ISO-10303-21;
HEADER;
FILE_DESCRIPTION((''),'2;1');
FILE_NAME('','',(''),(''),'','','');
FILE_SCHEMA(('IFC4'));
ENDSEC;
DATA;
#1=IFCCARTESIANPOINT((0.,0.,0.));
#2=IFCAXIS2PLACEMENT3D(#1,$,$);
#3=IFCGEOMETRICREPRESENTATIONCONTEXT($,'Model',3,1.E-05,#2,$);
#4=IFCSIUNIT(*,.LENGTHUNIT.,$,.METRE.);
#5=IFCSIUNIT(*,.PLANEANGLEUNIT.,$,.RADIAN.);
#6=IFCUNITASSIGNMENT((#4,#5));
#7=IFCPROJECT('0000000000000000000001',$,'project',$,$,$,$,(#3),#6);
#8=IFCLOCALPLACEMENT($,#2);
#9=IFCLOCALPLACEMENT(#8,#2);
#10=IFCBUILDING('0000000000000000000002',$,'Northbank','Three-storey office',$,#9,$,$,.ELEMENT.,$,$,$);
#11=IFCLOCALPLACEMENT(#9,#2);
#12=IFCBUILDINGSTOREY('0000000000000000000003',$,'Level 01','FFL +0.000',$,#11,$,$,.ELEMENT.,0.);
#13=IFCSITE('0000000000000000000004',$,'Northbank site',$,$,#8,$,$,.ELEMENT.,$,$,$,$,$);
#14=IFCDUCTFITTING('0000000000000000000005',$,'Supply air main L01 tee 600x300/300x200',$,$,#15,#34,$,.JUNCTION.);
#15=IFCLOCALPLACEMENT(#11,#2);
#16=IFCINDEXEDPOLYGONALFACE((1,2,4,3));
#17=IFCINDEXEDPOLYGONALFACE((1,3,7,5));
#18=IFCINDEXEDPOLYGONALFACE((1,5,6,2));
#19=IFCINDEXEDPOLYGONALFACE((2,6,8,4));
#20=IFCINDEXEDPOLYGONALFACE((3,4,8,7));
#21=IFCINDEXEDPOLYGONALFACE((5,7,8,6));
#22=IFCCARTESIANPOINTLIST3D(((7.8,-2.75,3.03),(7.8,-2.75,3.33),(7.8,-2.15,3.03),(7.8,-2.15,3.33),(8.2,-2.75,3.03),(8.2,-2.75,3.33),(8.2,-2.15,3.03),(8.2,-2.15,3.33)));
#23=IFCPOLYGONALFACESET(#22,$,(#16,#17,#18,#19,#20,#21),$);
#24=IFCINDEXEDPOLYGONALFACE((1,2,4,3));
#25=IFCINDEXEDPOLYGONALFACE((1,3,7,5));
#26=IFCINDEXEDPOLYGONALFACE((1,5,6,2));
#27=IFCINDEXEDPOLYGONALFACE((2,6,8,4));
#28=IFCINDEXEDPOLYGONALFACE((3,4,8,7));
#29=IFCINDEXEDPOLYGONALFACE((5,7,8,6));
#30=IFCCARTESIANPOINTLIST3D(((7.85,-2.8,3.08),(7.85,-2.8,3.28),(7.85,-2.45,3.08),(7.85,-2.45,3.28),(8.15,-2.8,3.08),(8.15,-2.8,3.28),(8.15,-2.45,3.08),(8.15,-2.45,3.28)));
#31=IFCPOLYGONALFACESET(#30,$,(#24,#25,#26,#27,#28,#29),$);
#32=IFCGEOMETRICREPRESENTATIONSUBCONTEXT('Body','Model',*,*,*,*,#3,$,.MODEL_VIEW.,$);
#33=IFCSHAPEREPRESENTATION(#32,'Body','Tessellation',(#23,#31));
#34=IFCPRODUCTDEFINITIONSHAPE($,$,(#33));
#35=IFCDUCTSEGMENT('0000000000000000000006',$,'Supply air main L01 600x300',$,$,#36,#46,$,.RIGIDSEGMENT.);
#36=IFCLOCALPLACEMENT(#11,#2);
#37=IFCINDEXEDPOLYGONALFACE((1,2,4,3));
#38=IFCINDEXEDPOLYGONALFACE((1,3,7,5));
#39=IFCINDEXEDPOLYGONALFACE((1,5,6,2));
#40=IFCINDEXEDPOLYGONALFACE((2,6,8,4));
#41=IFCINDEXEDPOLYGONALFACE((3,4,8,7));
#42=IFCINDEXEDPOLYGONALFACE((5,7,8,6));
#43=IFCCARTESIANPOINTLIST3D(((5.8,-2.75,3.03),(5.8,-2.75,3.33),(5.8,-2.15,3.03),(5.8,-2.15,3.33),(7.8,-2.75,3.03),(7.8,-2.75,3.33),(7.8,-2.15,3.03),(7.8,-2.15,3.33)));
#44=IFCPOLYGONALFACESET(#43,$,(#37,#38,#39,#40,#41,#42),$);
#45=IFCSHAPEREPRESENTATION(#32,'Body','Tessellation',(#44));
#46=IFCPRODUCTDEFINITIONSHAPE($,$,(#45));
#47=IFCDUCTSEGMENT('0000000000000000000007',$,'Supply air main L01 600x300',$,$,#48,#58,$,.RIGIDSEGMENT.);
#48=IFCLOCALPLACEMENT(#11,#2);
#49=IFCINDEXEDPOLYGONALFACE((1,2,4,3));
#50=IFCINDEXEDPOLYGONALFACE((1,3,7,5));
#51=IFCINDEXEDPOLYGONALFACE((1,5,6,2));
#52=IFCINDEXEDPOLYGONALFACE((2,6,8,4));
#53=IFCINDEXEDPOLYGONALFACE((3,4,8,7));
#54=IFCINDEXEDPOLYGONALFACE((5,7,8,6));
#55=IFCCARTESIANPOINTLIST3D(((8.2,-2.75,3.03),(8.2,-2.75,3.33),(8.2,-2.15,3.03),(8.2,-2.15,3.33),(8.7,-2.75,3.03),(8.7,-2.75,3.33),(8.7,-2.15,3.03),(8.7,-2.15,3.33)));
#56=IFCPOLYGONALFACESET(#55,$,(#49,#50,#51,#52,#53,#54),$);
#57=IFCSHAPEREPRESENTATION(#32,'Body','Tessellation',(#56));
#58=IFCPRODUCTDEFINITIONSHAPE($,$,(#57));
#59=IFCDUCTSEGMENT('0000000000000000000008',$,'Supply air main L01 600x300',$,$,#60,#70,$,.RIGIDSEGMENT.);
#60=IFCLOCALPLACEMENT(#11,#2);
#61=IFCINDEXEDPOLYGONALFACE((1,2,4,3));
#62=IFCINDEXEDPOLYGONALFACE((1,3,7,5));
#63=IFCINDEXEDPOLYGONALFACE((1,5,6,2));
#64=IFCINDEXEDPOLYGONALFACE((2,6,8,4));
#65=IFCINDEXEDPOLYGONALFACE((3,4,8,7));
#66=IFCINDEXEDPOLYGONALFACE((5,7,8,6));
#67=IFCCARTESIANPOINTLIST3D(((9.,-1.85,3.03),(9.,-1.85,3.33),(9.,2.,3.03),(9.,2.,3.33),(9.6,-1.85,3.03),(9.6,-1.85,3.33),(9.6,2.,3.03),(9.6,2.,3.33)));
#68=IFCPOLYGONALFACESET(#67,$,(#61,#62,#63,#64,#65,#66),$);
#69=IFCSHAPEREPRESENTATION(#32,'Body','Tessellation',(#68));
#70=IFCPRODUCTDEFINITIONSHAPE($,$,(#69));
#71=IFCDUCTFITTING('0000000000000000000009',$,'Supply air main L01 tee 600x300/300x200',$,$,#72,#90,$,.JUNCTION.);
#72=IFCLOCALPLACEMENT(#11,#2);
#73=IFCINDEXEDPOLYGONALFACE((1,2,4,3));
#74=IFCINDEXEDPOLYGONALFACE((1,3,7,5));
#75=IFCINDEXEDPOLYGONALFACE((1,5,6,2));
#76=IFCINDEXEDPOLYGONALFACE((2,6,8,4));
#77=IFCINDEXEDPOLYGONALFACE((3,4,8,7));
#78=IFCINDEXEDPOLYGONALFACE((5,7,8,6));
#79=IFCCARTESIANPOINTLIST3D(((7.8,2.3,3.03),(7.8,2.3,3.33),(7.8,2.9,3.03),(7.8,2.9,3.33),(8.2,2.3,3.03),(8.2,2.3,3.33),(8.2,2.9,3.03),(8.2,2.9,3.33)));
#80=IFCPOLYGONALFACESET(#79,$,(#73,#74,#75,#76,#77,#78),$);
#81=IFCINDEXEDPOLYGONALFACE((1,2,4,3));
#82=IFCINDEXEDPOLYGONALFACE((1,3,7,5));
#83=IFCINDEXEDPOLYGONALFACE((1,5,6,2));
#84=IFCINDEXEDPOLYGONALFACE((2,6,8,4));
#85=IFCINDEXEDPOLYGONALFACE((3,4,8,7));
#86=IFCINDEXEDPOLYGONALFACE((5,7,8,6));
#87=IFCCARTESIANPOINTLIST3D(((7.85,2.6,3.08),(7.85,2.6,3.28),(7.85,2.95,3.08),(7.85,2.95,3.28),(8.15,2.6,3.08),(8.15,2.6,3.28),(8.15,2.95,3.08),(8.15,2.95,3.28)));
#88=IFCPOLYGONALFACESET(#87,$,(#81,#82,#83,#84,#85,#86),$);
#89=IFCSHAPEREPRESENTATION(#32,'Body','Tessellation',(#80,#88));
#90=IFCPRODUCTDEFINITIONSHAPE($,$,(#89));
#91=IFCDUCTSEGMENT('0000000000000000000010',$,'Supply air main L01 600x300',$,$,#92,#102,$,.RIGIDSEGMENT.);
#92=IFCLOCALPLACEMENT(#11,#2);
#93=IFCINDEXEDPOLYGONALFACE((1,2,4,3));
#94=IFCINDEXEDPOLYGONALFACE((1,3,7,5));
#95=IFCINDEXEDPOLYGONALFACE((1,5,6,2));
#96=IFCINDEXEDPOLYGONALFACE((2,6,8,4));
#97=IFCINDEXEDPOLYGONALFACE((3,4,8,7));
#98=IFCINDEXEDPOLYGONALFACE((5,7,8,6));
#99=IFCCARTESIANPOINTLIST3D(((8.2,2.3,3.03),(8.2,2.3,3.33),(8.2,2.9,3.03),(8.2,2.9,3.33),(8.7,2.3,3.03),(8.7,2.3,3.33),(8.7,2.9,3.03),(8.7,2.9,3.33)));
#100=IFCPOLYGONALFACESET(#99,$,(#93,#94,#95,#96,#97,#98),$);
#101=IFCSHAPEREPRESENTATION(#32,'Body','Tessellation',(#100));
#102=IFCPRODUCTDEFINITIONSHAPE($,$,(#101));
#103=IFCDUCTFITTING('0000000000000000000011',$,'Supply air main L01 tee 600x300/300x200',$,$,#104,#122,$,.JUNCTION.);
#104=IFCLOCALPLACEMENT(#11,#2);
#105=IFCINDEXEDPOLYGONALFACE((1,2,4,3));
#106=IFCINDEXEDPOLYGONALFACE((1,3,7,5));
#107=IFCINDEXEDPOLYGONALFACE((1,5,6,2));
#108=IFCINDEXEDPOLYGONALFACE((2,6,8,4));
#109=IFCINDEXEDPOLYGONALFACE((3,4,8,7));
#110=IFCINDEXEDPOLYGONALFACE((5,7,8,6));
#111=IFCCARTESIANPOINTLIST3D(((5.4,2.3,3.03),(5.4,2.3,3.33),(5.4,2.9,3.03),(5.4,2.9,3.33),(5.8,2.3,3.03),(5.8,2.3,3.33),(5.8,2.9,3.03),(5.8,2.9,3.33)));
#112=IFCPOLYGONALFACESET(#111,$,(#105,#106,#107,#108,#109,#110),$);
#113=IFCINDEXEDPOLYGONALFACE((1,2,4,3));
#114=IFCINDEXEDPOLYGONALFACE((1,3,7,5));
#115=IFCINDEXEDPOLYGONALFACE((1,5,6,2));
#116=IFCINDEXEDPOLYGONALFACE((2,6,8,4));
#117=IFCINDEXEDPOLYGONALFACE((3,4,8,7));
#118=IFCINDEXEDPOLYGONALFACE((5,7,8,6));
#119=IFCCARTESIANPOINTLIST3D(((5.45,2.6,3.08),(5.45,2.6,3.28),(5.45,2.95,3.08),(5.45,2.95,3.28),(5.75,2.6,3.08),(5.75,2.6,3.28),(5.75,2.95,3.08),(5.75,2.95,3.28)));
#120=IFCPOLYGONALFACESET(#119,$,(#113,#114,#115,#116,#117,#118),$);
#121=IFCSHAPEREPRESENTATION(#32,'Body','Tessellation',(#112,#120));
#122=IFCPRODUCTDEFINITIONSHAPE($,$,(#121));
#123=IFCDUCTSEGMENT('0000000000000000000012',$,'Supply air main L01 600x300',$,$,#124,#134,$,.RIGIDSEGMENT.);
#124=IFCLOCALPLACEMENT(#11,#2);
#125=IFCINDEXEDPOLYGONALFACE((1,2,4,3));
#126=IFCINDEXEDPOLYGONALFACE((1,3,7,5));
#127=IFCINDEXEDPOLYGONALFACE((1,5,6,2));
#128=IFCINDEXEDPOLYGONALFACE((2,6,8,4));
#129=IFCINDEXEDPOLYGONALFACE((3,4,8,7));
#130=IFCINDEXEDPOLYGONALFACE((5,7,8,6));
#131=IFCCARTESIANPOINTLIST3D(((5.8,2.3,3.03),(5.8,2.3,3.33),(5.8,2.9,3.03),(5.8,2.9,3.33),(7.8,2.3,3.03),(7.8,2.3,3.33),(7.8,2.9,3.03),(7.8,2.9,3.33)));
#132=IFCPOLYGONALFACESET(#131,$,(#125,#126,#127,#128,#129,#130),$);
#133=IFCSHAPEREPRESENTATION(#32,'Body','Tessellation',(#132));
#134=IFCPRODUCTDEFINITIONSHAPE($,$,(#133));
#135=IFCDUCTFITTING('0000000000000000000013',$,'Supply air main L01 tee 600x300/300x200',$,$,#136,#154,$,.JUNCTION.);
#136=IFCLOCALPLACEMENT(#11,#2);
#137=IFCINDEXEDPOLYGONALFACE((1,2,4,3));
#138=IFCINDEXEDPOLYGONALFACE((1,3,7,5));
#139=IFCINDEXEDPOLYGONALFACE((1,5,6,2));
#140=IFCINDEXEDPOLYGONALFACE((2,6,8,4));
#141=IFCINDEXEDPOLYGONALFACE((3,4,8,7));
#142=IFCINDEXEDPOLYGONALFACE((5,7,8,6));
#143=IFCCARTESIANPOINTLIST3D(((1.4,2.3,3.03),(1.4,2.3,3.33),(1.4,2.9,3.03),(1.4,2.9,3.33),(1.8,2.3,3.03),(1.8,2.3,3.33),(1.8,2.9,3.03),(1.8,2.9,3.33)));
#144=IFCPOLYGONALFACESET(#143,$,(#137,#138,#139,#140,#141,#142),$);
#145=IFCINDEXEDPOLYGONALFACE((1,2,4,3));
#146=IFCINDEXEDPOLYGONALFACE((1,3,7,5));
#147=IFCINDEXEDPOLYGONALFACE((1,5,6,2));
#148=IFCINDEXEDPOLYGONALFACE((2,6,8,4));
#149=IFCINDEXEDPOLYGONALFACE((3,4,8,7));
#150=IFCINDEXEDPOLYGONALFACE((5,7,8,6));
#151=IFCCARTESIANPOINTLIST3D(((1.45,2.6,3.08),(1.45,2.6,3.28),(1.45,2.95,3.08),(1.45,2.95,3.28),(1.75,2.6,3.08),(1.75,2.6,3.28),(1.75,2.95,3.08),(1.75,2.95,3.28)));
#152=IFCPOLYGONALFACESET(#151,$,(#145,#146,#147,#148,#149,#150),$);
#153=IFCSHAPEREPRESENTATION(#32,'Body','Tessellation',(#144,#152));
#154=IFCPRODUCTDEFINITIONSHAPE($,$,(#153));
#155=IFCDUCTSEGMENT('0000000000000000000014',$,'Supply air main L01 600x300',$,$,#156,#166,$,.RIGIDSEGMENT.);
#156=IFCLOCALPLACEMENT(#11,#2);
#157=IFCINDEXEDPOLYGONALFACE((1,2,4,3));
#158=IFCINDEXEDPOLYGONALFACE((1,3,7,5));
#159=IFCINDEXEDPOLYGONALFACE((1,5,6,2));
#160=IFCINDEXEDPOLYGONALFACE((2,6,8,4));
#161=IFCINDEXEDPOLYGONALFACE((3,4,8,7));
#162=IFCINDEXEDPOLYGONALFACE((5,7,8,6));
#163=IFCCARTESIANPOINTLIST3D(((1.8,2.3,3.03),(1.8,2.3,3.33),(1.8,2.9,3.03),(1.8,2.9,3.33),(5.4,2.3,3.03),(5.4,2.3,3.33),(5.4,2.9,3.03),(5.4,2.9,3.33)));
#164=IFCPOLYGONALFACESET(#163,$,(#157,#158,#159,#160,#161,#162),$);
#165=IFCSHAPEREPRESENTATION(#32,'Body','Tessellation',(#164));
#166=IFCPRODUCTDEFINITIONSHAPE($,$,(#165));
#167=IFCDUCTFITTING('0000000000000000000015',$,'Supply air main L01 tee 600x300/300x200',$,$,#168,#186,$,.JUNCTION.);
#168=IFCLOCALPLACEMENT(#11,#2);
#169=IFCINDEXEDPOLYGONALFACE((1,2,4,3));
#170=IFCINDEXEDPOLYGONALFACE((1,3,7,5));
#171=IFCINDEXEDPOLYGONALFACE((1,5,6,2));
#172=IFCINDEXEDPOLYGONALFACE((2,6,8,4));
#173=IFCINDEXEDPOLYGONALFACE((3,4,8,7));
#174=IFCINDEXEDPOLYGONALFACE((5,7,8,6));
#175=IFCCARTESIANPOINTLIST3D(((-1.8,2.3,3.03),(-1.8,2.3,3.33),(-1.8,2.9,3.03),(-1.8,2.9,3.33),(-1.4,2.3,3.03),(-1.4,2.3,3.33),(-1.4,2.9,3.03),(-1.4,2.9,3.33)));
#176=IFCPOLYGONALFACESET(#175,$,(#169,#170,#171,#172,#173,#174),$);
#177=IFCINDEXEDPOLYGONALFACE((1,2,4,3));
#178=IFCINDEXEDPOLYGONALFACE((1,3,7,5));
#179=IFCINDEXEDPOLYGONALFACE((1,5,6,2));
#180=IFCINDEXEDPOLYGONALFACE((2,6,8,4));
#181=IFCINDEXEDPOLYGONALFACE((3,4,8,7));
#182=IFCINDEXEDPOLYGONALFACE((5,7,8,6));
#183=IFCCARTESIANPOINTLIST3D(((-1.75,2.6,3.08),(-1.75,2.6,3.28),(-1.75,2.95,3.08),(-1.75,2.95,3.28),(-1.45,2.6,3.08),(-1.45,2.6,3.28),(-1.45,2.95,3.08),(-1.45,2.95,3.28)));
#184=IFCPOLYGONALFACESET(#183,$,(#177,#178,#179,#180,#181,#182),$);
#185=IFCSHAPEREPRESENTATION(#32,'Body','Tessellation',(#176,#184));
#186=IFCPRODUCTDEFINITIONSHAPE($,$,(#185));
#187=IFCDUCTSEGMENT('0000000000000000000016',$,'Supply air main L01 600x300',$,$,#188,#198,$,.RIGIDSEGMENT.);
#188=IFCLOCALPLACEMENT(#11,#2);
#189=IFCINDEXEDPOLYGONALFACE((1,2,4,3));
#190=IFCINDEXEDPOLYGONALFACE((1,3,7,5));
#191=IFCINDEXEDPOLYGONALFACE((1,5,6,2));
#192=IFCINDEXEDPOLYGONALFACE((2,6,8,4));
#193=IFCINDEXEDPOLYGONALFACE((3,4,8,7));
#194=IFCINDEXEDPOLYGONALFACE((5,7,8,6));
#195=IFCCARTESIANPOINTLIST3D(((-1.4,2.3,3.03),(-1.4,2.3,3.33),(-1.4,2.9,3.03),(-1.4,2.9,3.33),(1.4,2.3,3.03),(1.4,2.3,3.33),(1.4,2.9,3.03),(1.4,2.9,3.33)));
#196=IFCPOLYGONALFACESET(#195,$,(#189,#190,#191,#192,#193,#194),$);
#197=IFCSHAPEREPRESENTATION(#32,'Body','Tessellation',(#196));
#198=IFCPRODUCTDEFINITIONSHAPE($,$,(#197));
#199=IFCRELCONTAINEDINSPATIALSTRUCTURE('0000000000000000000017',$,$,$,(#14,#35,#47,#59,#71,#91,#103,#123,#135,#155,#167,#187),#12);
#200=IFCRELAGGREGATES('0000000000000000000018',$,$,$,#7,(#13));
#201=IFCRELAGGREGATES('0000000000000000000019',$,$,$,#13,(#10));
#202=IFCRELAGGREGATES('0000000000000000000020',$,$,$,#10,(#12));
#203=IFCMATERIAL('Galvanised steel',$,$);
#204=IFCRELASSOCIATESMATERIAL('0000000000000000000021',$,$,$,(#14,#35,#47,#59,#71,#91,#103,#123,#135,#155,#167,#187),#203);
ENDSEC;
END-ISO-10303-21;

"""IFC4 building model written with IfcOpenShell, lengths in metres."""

from ifc_helpers import new_model, si_unit, frame, origin, place, context, subcontext, project, spatial, rectangle, extrude, material, element, save


model = new_model("IFC4")

# Units and contexts
model_context = context("Model", 3, precision=1e-05, world=origin())
body_context = subcontext(model_context, "Body", "Model", "MODEL_VIEW")
ifc_project = project(units=[si_unit("LENGTHUNIT", "METRE"), si_unit("PLANEANGLEUNIT", "RADIAN")], contexts=[model_context])

# Site, building, storey
site_placement = place(None, origin())
site = spatial("IfcSite", under=ifc_project, at=site_placement, Name="Northbank site", CompositionType="ELEMENT")
building_placement = place(site_placement, origin())
building = spatial("IfcBuilding", under=site, at=building_placement, Name="Northbank", Description="Three-storey office", CompositionType="ELEMENT")
storey_placement = place(building_placement, origin())
storey = spatial("IfcBuildingStorey", under=building, at=storey_placement, Name="Level 01", Description="FFL +0.000", CompositionType="ELEMENT", Elevation=0.0)

# Shared definitions
ifc_material_1 = material(Name="Galvanised steel")

# Duct fitting
duct_fitting_1_placement = place(storey_placement, origin())
element("IfcDuctFitting", 1, at=duct_fitting_1_placement, inside=storey, material=ifc_material_1, Name="Supply air main L01 tee 600x300/300x200", PredefinedType="JUNCTION", context=body_context, shape_type="SweptSolid", body=[
    extrude(rectangle(XDim=0.6, YDim=0.3), frame((7.8, -2.45, 3.18), z_axis=(1.0, 0.0, 0.0), x_axis=(0.0, 1.0, 0.0)), (0.0, 0.0, 1.0), 0.4),
    extrude(rectangle(XDim=0.3, YDim=0.2), frame((8.0, -2.45, 3.18), z_axis=(0.0, -1.0, 0.0), x_axis=(1.0, 0.0, 0.0)), (0.0, 0.0, 1.0), 0.35),
])

# Duct segments
duct_segment_1_placement = place(storey_placement, origin())
element("IfcDuctSegment", 2, at=duct_segment_1_placement, inside=storey, material=ifc_material_1, Name="Supply air main L01 600x300", PredefinedType="RIGIDSEGMENT", context=body_context, shape_type="SweptSolid", body=[
    extrude(rectangle(XDim=0.6, YDim=0.3), frame((5.8, -2.45, 3.18), z_axis=(1.0, 0.0, 0.0), x_axis=(0.0, 1.0, 0.0)), (0.0, 0.0, 1.0), 2.0),
])
duct_segment_2_placement = place(storey_placement, origin())
element("IfcDuctSegment", 3, at=duct_segment_2_placement, inside=storey, material=ifc_material_1, Name="Supply air main L01 600x300", PredefinedType="RIGIDSEGMENT", context=body_context, shape_type="SweptSolid", body=[
    extrude(rectangle(XDim=0.6, YDim=0.3), frame((8.2, -2.45, 3.18), z_axis=(1.0, 0.0, 0.0), x_axis=(0.0, 1.0, 0.0)), (0.0, 0.0, 1.0), 0.5),
])
duct_segment_3_placement = place(storey_placement, origin())
element("IfcDuctSegment", 4, at=duct_segment_3_placement, inside=storey, material=ifc_material_1, Name="Supply air main L01 600x300", PredefinedType="RIGIDSEGMENT", context=body_context, shape_type="SweptSolid", body=[
    extrude(rectangle(XDim=0.6, YDim=0.3), frame((9.3, -1.85, 3.18), z_axis=(0.0, 1.0, 0.0), x_axis=(-1.0, 0.0, 0.0)), (0.0, 0.0, 1.0), 3.85),
])

# Duct fitting
duct_fitting_2_placement = place(storey_placement, origin())
element("IfcDuctFitting", 5, at=duct_fitting_2_placement, inside=storey, material=ifc_material_1, Name="Supply air main L01 tee 600x300/300x200", PredefinedType="JUNCTION", context=body_context, shape_type="SweptSolid", body=[
    extrude(rectangle(XDim=0.6, YDim=0.3), frame((8.2, 2.6, 3.18), z_axis=(-1.0, 0.0, 0.0), x_axis=(0.0, -1.0, 0.0)), (0.0, 0.0, 1.0), 0.4),
    extrude(rectangle(XDim=0.3, YDim=0.2), frame((8.0, 2.6, 3.18), z_axis=(0.0, 1.0, 0.0), x_axis=(-1.0, 0.0, 0.0)), (0.0, 0.0, 1.0), 0.35),
])

# Duct segment
duct_segment_4_placement = place(storey_placement, origin())
element("IfcDuctSegment", 6, at=duct_segment_4_placement, inside=storey, material=ifc_material_1, Name="Supply air main L01 600x300", PredefinedType="RIGIDSEGMENT", context=body_context, shape_type="SweptSolid", body=[
    extrude(rectangle(XDim=0.6, YDim=0.3), frame((8.7, 2.6, 3.18), z_axis=(-1.0, 0.0, 0.0), x_axis=(0.0, -1.0, 0.0)), (0.0, 0.0, 1.0), 0.5),
])

# Duct fitting
duct_fitting_3_placement = place(storey_placement, origin())
element("IfcDuctFitting", 7, at=duct_fitting_3_placement, inside=storey, material=ifc_material_1, Name="Supply air main L01 tee 600x300/300x200", PredefinedType="JUNCTION", context=body_context, shape_type="SweptSolid", body=[
    extrude(rectangle(XDim=0.6, YDim=0.3), frame((5.8, 2.6, 3.18), z_axis=(-1.0, 0.0, 0.0), x_axis=(0.0, -1.0, 0.0)), (0.0, 0.0, 1.0), 0.4),
    extrude(rectangle(XDim=0.3, YDim=0.2), frame((5.6, 2.6, 3.18), z_axis=(0.0, 1.0, 0.0), x_axis=(-1.0, 0.0, 0.0)), (0.0, 0.0, 1.0), 0.35),
])

# Duct segment
duct_segment_5_placement = place(storey_placement, origin())
element("IfcDuctSegment", 8, at=duct_segment_5_placement, inside=storey, material=ifc_material_1, Name="Supply air main L01 600x300", PredefinedType="RIGIDSEGMENT", context=body_context, shape_type="SweptSolid", body=[
    extrude(rectangle(XDim=0.6, YDim=0.3), frame((7.8, 2.6, 3.18), z_axis=(-1.0, 0.0, 0.0), x_axis=(0.0, -1.0, 0.0)), (0.0, 0.0, 1.0), 2.0),
])

# Duct fitting
duct_fitting_4_placement = place(storey_placement, origin())
element("IfcDuctFitting", 9, at=duct_fitting_4_placement, inside=storey, material=ifc_material_1, Name="Supply air main L01 tee 600x300/300x200", PredefinedType="JUNCTION", context=body_context, shape_type="SweptSolid", body=[
    extrude(rectangle(XDim=0.6, YDim=0.3), frame((1.8, 2.6, 3.18), z_axis=(-1.0, 0.0, 0.0), x_axis=(0.0, -1.0, 0.0)), (0.0, 0.0, 1.0), 0.4),
    extrude(rectangle(XDim=0.3, YDim=0.2), frame((1.6, 2.6, 3.18), z_axis=(0.0, 1.0, 0.0), x_axis=(-1.0, 0.0, 0.0)), (0.0, 0.0, 1.0), 0.35),
])

# Duct segment
duct_segment_6_placement = place(storey_placement, origin())
element("IfcDuctSegment", 10, at=duct_segment_6_placement, inside=storey, material=ifc_material_1, Name="Supply air main L01 600x300", PredefinedType="RIGIDSEGMENT", context=body_context, shape_type="SweptSolid", body=[
    extrude(rectangle(XDim=0.6, YDim=0.3), frame((5.4, 2.6, 3.18), z_axis=(-1.0, 0.0, 0.0), x_axis=(0.0, -1.0, 0.0)), (0.0, 0.0, 1.0), 3.6),
])

# Duct fitting
duct_fitting_5_placement = place(storey_placement, origin())
element("IfcDuctFitting", 11, at=duct_fitting_5_placement, inside=storey, material=ifc_material_1, Name="Supply air main L01 tee 600x300/300x200", PredefinedType="JUNCTION", context=body_context, shape_type="SweptSolid", body=[
    extrude(rectangle(XDim=0.6, YDim=0.3), frame((-1.4, 2.6, 3.18), z_axis=(-1.0, 0.0, 0.0), x_axis=(0.0, -1.0, 0.0)), (0.0, 0.0, 1.0), 0.4),
    extrude(rectangle(XDim=0.3, YDim=0.2), frame((-1.6, 2.6, 3.18), z_axis=(0.0, 1.0, 0.0), x_axis=(-1.0, 0.0, 0.0)), (0.0, 0.0, 1.0), 0.35),
])

# Duct segment
duct_segment_7_placement = place(storey_placement, origin())
element("IfcDuctSegment", 12, at=duct_segment_7_placement, inside=storey, material=ifc_material_1, Name="Supply air main L01 600x300", PredefinedType="RIGIDSEGMENT", context=body_context, shape_type="SweptSolid", body=[
    extrude(rectangle(XDim=0.6, YDim=0.3), frame((1.4, 2.6, 3.18), z_axis=(-1.0, 0.0, 0.0), x_axis=(0.0, -1.0, 0.0)), (0.0, 0.0, 1.0), 2.8),
])

save(model, "model.ifc")
